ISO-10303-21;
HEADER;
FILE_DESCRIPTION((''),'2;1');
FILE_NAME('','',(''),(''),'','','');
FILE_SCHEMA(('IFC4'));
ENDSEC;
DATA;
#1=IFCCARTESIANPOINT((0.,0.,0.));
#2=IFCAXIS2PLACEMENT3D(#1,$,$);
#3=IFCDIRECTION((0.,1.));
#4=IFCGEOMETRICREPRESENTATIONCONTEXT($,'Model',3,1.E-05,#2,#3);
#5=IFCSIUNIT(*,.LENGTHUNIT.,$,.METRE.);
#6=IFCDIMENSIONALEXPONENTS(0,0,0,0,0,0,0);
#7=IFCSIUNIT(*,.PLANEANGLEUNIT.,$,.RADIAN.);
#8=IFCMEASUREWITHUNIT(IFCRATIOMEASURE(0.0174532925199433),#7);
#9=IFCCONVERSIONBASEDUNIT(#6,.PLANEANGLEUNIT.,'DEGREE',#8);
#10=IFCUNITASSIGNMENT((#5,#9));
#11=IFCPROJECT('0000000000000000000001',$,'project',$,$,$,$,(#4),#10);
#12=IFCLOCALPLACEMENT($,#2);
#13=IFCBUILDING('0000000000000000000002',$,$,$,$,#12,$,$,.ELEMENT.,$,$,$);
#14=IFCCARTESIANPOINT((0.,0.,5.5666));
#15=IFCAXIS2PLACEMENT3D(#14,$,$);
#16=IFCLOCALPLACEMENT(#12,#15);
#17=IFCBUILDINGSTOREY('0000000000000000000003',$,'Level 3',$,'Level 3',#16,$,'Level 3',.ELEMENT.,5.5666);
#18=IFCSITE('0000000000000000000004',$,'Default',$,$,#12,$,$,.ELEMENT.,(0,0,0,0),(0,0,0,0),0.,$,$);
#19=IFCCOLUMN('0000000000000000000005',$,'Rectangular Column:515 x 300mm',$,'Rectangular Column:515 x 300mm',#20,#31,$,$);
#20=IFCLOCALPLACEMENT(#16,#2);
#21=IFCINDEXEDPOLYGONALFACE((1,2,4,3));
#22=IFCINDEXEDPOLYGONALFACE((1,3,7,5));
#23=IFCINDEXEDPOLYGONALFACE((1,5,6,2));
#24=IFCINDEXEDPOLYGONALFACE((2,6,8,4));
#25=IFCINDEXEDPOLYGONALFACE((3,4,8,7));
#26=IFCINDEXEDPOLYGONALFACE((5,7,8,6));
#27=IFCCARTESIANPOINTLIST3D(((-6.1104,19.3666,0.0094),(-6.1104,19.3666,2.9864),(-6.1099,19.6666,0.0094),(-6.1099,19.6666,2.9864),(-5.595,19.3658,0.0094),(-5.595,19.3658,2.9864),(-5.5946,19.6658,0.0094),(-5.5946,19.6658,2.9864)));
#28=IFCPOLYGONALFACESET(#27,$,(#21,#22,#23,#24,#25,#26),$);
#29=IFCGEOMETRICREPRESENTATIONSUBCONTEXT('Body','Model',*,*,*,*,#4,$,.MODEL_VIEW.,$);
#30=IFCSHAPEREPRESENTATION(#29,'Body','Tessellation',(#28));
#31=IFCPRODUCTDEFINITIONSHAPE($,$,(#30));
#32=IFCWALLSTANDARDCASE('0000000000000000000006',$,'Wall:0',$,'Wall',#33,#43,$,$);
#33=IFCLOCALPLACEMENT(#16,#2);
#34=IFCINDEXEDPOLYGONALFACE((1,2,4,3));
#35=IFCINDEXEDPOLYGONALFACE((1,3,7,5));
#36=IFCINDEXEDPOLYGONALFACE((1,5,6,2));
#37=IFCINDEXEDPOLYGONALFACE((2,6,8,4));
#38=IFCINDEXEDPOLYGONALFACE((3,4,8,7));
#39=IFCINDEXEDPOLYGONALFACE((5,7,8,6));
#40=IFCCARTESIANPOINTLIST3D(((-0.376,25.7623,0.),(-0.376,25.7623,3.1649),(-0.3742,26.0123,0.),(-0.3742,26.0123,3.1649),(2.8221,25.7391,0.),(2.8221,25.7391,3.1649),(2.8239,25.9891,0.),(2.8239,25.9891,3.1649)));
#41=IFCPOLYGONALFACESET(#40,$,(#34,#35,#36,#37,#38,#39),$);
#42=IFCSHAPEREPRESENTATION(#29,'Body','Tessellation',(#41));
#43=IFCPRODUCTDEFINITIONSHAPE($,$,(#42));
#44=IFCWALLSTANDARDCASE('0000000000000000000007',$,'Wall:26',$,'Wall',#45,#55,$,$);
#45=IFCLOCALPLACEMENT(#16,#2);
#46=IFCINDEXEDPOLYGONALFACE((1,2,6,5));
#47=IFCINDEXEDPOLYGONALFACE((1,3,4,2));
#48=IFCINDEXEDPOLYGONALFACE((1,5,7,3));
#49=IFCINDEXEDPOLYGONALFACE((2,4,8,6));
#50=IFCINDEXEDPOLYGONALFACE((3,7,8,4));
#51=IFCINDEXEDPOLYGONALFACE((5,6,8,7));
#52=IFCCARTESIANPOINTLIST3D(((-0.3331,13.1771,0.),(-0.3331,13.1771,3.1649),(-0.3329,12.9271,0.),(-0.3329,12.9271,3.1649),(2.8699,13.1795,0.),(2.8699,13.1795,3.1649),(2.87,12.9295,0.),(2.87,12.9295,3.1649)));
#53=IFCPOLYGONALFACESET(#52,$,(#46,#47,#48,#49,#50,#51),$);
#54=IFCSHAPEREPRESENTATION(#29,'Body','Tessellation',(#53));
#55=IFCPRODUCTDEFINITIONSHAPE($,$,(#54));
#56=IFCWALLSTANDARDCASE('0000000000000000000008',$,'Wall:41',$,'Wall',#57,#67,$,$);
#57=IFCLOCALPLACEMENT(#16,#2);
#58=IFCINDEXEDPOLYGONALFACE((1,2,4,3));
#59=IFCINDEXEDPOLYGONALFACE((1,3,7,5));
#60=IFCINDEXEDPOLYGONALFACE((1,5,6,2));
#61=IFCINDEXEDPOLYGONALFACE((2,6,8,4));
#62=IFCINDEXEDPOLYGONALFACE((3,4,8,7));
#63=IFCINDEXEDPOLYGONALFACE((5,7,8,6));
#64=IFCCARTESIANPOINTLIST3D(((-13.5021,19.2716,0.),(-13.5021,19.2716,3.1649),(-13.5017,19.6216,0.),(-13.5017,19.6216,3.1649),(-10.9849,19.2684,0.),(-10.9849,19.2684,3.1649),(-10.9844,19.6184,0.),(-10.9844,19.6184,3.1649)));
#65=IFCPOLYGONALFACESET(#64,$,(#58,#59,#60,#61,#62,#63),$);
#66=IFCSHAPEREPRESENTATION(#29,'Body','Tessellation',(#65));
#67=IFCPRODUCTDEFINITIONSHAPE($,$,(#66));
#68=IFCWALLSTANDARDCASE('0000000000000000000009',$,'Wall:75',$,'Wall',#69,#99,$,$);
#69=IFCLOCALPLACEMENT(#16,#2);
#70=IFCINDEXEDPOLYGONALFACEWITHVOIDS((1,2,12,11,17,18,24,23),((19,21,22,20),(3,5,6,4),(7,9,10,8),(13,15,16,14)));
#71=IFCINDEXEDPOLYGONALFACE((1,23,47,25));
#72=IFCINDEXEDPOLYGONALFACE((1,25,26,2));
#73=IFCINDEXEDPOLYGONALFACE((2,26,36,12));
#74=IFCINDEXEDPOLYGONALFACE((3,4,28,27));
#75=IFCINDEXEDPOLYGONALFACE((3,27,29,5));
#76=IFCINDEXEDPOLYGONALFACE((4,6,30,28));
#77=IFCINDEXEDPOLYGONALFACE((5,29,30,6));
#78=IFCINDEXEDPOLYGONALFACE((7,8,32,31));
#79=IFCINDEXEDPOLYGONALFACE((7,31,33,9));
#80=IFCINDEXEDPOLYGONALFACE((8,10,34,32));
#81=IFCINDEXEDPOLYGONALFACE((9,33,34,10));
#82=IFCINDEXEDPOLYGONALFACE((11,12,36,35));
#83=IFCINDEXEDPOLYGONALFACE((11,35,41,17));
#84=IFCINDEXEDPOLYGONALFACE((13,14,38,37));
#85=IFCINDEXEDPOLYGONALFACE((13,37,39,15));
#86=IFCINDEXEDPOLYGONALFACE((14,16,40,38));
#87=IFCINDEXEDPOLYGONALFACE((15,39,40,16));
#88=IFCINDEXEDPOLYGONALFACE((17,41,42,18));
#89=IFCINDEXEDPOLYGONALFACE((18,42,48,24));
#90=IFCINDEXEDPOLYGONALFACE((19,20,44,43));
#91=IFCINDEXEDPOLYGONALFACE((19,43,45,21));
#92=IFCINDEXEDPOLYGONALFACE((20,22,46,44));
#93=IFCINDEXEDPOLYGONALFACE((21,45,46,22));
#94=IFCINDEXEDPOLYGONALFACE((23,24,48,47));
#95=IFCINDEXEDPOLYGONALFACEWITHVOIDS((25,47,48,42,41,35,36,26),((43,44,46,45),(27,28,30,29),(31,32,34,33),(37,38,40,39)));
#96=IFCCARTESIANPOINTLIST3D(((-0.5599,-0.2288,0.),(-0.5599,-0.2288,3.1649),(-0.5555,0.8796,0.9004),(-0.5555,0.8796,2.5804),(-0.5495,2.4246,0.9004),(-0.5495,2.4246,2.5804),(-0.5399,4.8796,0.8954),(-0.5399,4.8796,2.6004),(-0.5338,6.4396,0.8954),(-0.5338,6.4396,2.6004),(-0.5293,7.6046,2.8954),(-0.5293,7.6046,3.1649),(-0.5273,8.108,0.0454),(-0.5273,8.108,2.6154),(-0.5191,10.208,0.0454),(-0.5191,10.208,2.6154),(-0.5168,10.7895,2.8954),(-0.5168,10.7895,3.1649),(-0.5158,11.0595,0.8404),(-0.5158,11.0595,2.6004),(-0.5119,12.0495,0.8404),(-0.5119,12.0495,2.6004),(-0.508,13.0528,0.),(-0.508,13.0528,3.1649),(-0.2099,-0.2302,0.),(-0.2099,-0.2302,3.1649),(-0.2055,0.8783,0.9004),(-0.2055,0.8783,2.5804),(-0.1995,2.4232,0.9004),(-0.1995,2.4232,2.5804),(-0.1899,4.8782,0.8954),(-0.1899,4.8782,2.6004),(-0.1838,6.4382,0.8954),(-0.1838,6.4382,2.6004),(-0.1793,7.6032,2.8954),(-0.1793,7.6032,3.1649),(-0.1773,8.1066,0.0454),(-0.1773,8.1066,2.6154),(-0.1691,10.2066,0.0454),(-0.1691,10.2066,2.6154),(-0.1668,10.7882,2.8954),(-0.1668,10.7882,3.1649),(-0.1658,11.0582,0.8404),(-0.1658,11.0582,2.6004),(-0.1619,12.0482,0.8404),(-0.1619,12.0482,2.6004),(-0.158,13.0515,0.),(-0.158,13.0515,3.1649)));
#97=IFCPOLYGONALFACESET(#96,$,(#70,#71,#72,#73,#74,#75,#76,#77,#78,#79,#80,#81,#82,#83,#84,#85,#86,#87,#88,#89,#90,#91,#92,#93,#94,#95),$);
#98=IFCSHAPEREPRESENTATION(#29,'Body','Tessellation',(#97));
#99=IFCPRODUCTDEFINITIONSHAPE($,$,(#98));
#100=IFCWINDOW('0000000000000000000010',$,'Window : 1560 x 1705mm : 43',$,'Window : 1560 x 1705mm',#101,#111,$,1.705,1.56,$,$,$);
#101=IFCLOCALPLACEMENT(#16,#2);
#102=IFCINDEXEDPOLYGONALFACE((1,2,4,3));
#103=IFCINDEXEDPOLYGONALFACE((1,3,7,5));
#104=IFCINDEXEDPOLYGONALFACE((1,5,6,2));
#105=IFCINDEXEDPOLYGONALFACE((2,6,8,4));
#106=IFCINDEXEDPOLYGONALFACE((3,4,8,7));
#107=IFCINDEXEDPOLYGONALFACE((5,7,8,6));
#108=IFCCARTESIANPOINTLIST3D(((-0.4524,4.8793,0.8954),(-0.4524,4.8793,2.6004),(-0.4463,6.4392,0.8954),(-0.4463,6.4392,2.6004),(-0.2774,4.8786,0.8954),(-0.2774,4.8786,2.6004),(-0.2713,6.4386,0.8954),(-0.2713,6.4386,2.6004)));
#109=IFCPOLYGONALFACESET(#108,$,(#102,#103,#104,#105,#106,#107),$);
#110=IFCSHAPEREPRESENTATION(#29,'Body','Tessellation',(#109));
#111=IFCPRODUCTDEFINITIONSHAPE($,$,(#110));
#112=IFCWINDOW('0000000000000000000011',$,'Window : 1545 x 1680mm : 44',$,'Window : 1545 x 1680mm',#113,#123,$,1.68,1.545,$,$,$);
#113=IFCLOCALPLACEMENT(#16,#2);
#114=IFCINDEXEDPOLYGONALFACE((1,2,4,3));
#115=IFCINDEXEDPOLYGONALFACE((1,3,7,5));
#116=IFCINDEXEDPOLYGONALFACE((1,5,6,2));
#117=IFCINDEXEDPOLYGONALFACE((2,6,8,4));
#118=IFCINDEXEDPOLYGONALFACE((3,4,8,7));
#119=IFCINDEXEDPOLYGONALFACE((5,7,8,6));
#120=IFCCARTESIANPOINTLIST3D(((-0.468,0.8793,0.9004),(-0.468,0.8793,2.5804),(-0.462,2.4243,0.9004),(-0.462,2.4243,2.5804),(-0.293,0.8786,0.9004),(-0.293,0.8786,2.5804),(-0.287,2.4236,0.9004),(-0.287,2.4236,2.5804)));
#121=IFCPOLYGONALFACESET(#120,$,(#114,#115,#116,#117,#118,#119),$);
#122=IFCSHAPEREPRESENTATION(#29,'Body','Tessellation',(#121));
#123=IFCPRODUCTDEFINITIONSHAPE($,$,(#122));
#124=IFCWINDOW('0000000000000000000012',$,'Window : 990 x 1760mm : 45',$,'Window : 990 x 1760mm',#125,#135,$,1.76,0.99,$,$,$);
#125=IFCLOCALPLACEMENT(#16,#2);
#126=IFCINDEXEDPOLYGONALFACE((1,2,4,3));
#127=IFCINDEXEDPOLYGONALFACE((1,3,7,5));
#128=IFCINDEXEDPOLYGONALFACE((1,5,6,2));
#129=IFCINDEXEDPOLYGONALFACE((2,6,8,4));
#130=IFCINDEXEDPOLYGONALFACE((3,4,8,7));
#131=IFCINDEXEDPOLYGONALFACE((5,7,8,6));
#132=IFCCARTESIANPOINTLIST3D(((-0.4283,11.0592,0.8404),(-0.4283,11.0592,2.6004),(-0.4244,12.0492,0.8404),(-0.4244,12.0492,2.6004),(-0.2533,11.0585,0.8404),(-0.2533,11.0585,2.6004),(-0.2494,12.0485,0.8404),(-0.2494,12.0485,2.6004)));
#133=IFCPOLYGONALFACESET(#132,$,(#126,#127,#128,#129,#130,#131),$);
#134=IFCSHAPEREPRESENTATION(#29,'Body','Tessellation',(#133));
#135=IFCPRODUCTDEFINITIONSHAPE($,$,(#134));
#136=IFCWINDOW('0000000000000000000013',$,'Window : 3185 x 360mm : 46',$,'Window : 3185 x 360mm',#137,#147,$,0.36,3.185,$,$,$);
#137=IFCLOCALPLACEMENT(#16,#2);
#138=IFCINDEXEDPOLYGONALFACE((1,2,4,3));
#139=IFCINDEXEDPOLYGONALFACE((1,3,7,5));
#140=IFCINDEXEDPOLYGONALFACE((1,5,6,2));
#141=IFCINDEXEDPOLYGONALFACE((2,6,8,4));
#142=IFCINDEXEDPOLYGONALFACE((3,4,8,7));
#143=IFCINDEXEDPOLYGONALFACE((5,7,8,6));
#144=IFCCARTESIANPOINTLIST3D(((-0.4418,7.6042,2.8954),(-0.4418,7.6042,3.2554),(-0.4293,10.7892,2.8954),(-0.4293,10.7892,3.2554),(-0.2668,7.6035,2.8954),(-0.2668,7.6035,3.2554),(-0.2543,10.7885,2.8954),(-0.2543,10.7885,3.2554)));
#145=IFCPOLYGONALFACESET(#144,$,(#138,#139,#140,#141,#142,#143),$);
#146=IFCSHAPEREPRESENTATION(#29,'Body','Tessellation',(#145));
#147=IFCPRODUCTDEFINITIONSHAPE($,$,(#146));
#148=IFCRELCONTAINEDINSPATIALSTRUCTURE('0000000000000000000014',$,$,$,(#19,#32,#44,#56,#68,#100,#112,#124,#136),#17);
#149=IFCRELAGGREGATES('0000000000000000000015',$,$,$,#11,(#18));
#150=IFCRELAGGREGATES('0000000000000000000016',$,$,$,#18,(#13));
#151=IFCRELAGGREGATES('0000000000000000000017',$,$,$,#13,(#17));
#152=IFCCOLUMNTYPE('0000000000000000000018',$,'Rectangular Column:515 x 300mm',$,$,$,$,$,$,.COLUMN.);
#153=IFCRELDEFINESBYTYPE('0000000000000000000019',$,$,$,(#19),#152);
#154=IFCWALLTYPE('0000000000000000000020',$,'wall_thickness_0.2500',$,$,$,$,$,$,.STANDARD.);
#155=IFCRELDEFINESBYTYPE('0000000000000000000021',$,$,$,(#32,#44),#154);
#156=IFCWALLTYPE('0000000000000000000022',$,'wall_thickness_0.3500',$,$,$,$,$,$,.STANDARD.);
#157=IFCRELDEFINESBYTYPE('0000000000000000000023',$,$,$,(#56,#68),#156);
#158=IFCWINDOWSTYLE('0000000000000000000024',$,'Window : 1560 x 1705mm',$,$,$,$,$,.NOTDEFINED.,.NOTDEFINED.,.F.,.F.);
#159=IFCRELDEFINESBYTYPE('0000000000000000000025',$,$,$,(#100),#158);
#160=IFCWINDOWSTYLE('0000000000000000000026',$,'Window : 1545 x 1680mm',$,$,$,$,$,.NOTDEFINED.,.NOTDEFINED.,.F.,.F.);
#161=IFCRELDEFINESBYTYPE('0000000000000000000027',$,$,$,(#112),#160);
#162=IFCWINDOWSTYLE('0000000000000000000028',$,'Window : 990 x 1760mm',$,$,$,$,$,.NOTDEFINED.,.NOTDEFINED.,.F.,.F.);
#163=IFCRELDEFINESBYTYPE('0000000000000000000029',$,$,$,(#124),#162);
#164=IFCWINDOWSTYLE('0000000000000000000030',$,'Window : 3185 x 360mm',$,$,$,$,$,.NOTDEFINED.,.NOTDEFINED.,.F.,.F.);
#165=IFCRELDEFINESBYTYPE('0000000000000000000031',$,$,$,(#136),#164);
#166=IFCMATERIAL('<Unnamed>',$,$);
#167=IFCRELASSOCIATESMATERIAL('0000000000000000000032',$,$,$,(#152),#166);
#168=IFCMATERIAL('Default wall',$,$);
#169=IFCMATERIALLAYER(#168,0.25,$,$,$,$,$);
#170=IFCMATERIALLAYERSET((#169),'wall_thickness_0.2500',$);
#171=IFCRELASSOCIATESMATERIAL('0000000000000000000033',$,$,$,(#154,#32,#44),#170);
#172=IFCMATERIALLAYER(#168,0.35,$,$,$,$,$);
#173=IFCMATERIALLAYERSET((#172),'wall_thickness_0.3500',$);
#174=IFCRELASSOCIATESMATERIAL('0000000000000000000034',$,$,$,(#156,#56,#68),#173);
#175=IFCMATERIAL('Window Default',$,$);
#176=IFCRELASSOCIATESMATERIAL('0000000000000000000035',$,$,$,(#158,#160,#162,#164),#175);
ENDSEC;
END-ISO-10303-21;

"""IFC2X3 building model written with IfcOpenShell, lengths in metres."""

from ifc_helpers import new_model, entity, si_unit, converted_unit, direction, frame, frame_2d, origin, origin_2d_with_axis, place, context, subcontext, project, spatial, polyline, rectangle, outline, extrude, source, transform, mapped, material, layer, layer_set, layer_usage, type_object, type_shapes, element, fill, save


model = new_model("IFC2X3")

# Units and contexts
model_context = context("Model", 3, precision=1e-05, world=origin(), true_north=direction((0.0, 1.0)))
body_context = subcontext(model_context, "Body", "Model", "MODEL_VIEW")
ifc_project = project(units=[si_unit("LENGTHUNIT", "METRE"), converted_unit("PLANEANGLEUNIT", "DEGREE", entity("IfcRatioMeasure", 0.0174532925199433), si_unit("PLANEANGLEUNIT", "RADIAN"), dimensions=[0, 0, 0, 0, 0, 0, 0])], contexts=[model_context])

# Site, building, storey
placement_1 = place(None, origin())
site = spatial("IfcSite", under=ifc_project, at=placement_1, Name="Default", CompositionType="ELEMENT", RefLatitude=(0, 0, 0, 0), RefLongitude=(0, 0, 0, 0), RefElevation=0.0)
building = spatial("IfcBuilding", under=site, at=placement_1, CompositionType="ELEMENT")
storey_placement = place(placement_1, frame((0.0, 0.0, 5.5666)))
storey = spatial("IfcBuildingStorey", under=building, at=storey_placement, Name="Level 3", ObjectType="Level 3", LongName="Level 3", CompositionType="ELEMENT", Elevation=5.5666)

# Column
ifc_material_1 = material(Name="<Unnamed>")
column_type = type_object("IfcColumnType", Name="Rectangular Column:515 x 300mm", PredefinedType="COLUMN", material=ifc_material_1)
shared_shape_1 = source(origin(), body_context, "Body", "SweptSolid", [
    extrude(rectangle(XDim=0.5154, YDim=0.3, at=origin_2d_with_axis()), frame((0.0, 0.0, 0.0), z_axis=(0.0, 0.0, 1.0), x_axis=(0.0, -1.0, 0.0)), (0.0, 0.0, 1.0), 2.977),
])
type_shapes(column_type, [shared_shape_1])
column_placement = place(placement_1, frame((-5.8525, 19.5162, 5.576), z_axis=(0.0, 0.0, 1.0), x_axis=(-0.0014, -0.999999, 0.0)))
element("IfcColumn", 1, at=column_placement, inside=storey, type_object=column_type, Name="Rectangular Column:515 x 300mm", ObjectType="Rectangular Column:515 x 300mm", context=body_context, shape_type="MappedRepresentation", body=[
    mapped(shared_shape_1, transform((0.0, 0.0, 0.0), scale=1.0)),
])

# Walls
ifc_material_2 = material(Name="Default wall")
ifc_layer_1 = layer(ifc_material_2, 0.25)
ifc_layer_set_1 = layer_set([ifc_layer_1], Name="wall_thickness_0.2500")
ifc_layer_usage_1 = layer_usage(ifc_layer_set_1, "AXIS2", "POSITIVE", -0.125)
wall_type_1 = type_object("IfcWallType", Name="wall_thickness_0.2500", PredefinedType="STANDARD", material=ifc_layer_set_1)
wall_1_placement = place(storey_placement, frame((-0.3751, 25.8873, 0.0), z_axis=(0.0, 0.0, 1.0), x_axis=(0.999974, -0.007267, 0.0)))
element("IfcWallStandardCase", 2, at=wall_1_placement, inside=storey, type_object=wall_type_1, material=ifc_layer_usage_1, Name="Wall:0", ObjectType="Wall", context=body_context, shape_type="SweptSolid", body=[
    extrude(outline(polyline([(3.1982, -0.125), (3.1982, 0.125), (0.0, 0.125), (0.0, -0.125), (3.1982, -0.125)])), origin(), (0.0, 0.0, 1.0), 3.1649),
])
wall_2_placement = place(storey_placement, frame((-0.333, 13.0521, 0.0), z_axis=(0.0, 0.0, 1.0), x_axis=(1.0, 0.000726, 0.0)))
element("IfcWallStandardCase", 3, at=wall_2_placement, inside=storey, type_object=wall_type_1, material=ifc_layer_usage_1, Name="Wall:26", ObjectType="Wall", context=body_context, shape_type="SweptSolid", body=[
    extrude(outline(polyline([(3.203, -0.125), (3.203, 0.125), (0.0, 0.125), (0.0, -0.125), (3.203, -0.125)])), origin(), (0.0, 0.0, 1.0), 3.1649),
])
ifc_layer_2 = layer(ifc_material_2, 0.35)
ifc_layer_set_2 = layer_set([ifc_layer_2], Name="wall_thickness_0.3500")
ifc_layer_usage_2 = layer_usage(ifc_layer_set_2, "AXIS2", "POSITIVE", -0.175)
wall_type_2 = type_object("IfcWallType", Name="wall_thickness_0.3500", PredefinedType="STANDARD", material=ifc_layer_set_2)
wall_3_placement = place(storey_placement, frame((-13.5019, 19.4466, 0.0), z_axis=(0.0, 0.0, 1.0), x_axis=(0.999999, -0.001234, 0.0)))
element("IfcWallStandardCase", 4, at=wall_3_placement, inside=storey, type_object=wall_type_2, material=ifc_layer_usage_2, Name="Wall:41", ObjectType="Wall", context=body_context, shape_type="SweptSolid", body=[
    extrude(outline(polyline([(2.5172, -0.175), (2.5172, 0.175), (0.0, 0.175), (0.0, -0.175), (2.5172, -0.175)])), origin(), (0.0, 0.0, 1.0), 3.1649),
])

# Wall, openings, windows
wall_4_placement = place(storey_placement, frame((-0.333, 13.0521, 0.0), z_axis=(0.0, 0.0, 1.0), x_axis=(-0.003903, -0.999992, 0.0)))
wall_4 = element("IfcWallStandardCase", 5, at=wall_4_placement, inside=storey, type_object=wall_type_2, material=ifc_layer_usage_2, Name="Wall:75", ObjectType="Wall", context=body_context, shape_type="SweptSolid", body=[
    extrude(outline(polyline([(13.2817, -0.175), (13.2817, 0.175), (0.0, 0.175), (0.0, -0.175), (13.2817, -0.175)])), origin(), (0.0, 0.0, 1.0), 3.1649),
])
opening_1_placement = place(wall_4_placement, frame((2.8449, -0.175, 0.0454)))
element("IfcOpeningElement", 6, at=opening_1_placement, cuts=wall_4, ObjectType="Opening", context=body_context, shape_type="SweptSolid", body=[
    extrude(rectangle(XDim=2.1, YDim=2.57, at=frame_2d((1.285, 1.05), x_axis=(0.0, 1.0))), frame((0.0, 0.0, 0.0), z_axis=(0.0, 1.0, 0.0), x_axis=(0.0, 0.0, 1.0)), (0.0, 0.0, 1.0), 0.35),
])
opening_2_placement = place(wall_4_placement, frame((6.6133, -0.175, 0.8954)))
opening_2 = element("IfcOpeningElement", 7, at=opening_2_placement, cuts=wall_4, ObjectType="Opening", context=body_context, shape_type="SweptSolid", body=[
    extrude(rectangle(XDim=1.56, YDim=1.705, at=frame_2d((0.8525, 0.78), x_axis=(0.0, 1.0))), frame((0.0, 0.0, 0.0), z_axis=(0.0, 1.0, 0.0), x_axis=(0.0, 0.0, 1.0)), (0.0, 0.0, 1.0), 0.35),
])
opening_3_placement = place(wall_4_placement, frame((10.6283, -0.175, 0.9004)))
opening_3 = element("IfcOpeningElement", 8, at=opening_3_placement, cuts=wall_4, ObjectType="Opening", context=body_context, shape_type="SweptSolid", body=[
    extrude(rectangle(XDim=1.545, YDim=1.68, at=frame_2d((0.84, 0.7725), x_axis=(0.0, 1.0))), frame((0.0, 0.0, 0.0), z_axis=(0.0, 1.0, 0.0), x_axis=(0.0, 0.0, 1.0)), (0.0, 0.0, 1.0), 0.35),
])
opening_4_placement = place(wall_4_placement, frame((1.0033, -0.175, 0.8404)))
opening_4 = element("IfcOpeningElement", 9, at=opening_4_placement, cuts=wall_4, ObjectType="Opening", context=body_context, shape_type="SweptSolid", body=[
    extrude(rectangle(XDim=0.99, YDim=1.76, at=frame_2d((0.88, 0.495), x_axis=(0.0, 1.0))), frame((0.0, 0.0, 0.0), z_axis=(0.0, 1.0, 0.0), x_axis=(0.0, 0.0, 1.0)), (0.0, 0.0, 1.0), 0.35),
])
opening_5_placement = place(wall_4_placement, frame((2.2633, -0.175, 2.8954)))
opening_5 = element("IfcOpeningElement", 10, at=opening_5_placement, cuts=wall_4, ObjectType="Opening", context=body_context, shape_type="SweptSolid", body=[
    extrude(rectangle(XDim=3.185, YDim=0.36, at=frame_2d((0.18, 1.5925), x_axis=(0.0, 1.0))), frame((0.0, 0.0, 0.0), z_axis=(0.0, 1.0, 0.0), x_axis=(0.0, 0.0, 1.0)), (0.0, 0.0, 1.0), 0.35),
])
ifc_material_3 = material(Name="Window Default")
window_style_1 = type_object("IfcWindowStyle", Name="Window : 1560 x 1705mm", ConstructionType="NOTDEFINED", OperationType="NOTDEFINED", ParameterTakesPrecedence=False, Sizeable=False, material=ifc_material_3)
shared_shape_2 = source(origin(), body_context, "Body", "SweptSolid", [
    extrude(rectangle(XDim=0.175, YDim=1.56, at=origin_2d_with_axis()), frame((0.78, 0.175, 0.0), z_axis=(0.0, 0.0, 1.0), x_axis=(0.0, 1.0, 0.0)), (0.0, 0.0, 1.0), 1.705),
])
type_shapes(window_style_1, [shared_shape_2])
window_1_placement = place(opening_2_placement, origin())
window_1 = element("IfcWindow", 11, at=window_1_placement, inside=storey, type_object=window_style_1, Name="Window : 1560 x 1705mm : 43", ObjectType="Window : 1560 x 1705mm", OverallHeight=1.705, OverallWidth=1.56, context=body_context, shape_type="MappedRepresentation", body=[
    mapped(shared_shape_2, transform((0.0, 0.0, 0.0), scale=1.0)),
])
fill(opening_2, window_1)
window_style_2 = type_object("IfcWindowStyle", Name="Window : 1545 x 1680mm", ConstructionType="NOTDEFINED", OperationType="NOTDEFINED", ParameterTakesPrecedence=False, Sizeable=False, material=ifc_material_3)
shared_shape_3 = source(origin(), body_context, "Body", "SweptSolid", [
    extrude(rectangle(XDim=0.175, YDim=1.545, at=origin_2d_with_axis()), frame((0.7725, 0.175, 0.0), z_axis=(0.0, 0.0, 1.0), x_axis=(0.0, 1.0, 0.0)), (0.0, 0.0, 1.0), 1.68),
])
type_shapes(window_style_2, [shared_shape_3])
window_2_placement = place(opening_3_placement, origin())
window_2 = element("IfcWindow", 12, at=window_2_placement, inside=storey, type_object=window_style_2, Name="Window : 1545 x 1680mm : 44", ObjectType="Window : 1545 x 1680mm", OverallHeight=1.68, OverallWidth=1.545, context=body_context, shape_type="MappedRepresentation", body=[
    mapped(shared_shape_3, transform((0.0, 0.0, 0.0), scale=1.0)),
])
fill(opening_3, window_2)
window_style_3 = type_object("IfcWindowStyle", Name="Window : 990 x 1760mm", ConstructionType="NOTDEFINED", OperationType="NOTDEFINED", ParameterTakesPrecedence=False, Sizeable=False, material=ifc_material_3)
shared_shape_4 = source(origin(), body_context, "Body", "SweptSolid", [
    extrude(rectangle(XDim=0.175, YDim=0.99, at=origin_2d_with_axis()), frame((0.495, 0.175, 0.0), z_axis=(0.0, 0.0, 1.0), x_axis=(0.0, 1.0, 0.0)), (0.0, 0.0, 1.0), 1.76),
])
type_shapes(window_style_3, [shared_shape_4])
window_3_placement = place(opening_4_placement, origin())
window_3 = element("IfcWindow", 13, at=window_3_placement, inside=storey, type_object=window_style_3, Name="Window : 990 x 1760mm : 45", ObjectType="Window : 990 x 1760mm", OverallHeight=1.76, OverallWidth=0.99, context=body_context, shape_type="MappedRepresentation", body=[
    mapped(shared_shape_4, transform((0.0, 0.0, 0.0), scale=1.0)),
])
fill(opening_4, window_3)
window_style_4 = type_object("IfcWindowStyle", Name="Window : 3185 x 360mm", ConstructionType="NOTDEFINED", OperationType="NOTDEFINED", ParameterTakesPrecedence=False, Sizeable=False, material=ifc_material_3)
shared_shape_5 = source(origin(), body_context, "Body", "SweptSolid", [
    extrude(rectangle(XDim=0.175, YDim=3.185, at=origin_2d_with_axis()), frame((1.5925, 0.175, 0.0), z_axis=(0.0, 0.0, 1.0), x_axis=(0.0, 1.0, 0.0)), (0.0, 0.0, 1.0), 0.36),
])
type_shapes(window_style_4, [shared_shape_5])
window_4_placement = place(opening_5_placement, origin())
window_4 = element("IfcWindow", 14, at=window_4_placement, inside=storey, type_object=window_style_4, Name="Window : 3185 x 360mm : 46", ObjectType="Window : 3185 x 360mm", OverallHeight=0.36, OverallWidth=3.185, context=body_context, shape_type="MappedRepresentation", body=[
    mapped(shared_shape_5, transform((0.0, 0.0, 0.0), scale=1.0)),
])
fill(opening_5, window_4)

save(model, "model.ifc")
